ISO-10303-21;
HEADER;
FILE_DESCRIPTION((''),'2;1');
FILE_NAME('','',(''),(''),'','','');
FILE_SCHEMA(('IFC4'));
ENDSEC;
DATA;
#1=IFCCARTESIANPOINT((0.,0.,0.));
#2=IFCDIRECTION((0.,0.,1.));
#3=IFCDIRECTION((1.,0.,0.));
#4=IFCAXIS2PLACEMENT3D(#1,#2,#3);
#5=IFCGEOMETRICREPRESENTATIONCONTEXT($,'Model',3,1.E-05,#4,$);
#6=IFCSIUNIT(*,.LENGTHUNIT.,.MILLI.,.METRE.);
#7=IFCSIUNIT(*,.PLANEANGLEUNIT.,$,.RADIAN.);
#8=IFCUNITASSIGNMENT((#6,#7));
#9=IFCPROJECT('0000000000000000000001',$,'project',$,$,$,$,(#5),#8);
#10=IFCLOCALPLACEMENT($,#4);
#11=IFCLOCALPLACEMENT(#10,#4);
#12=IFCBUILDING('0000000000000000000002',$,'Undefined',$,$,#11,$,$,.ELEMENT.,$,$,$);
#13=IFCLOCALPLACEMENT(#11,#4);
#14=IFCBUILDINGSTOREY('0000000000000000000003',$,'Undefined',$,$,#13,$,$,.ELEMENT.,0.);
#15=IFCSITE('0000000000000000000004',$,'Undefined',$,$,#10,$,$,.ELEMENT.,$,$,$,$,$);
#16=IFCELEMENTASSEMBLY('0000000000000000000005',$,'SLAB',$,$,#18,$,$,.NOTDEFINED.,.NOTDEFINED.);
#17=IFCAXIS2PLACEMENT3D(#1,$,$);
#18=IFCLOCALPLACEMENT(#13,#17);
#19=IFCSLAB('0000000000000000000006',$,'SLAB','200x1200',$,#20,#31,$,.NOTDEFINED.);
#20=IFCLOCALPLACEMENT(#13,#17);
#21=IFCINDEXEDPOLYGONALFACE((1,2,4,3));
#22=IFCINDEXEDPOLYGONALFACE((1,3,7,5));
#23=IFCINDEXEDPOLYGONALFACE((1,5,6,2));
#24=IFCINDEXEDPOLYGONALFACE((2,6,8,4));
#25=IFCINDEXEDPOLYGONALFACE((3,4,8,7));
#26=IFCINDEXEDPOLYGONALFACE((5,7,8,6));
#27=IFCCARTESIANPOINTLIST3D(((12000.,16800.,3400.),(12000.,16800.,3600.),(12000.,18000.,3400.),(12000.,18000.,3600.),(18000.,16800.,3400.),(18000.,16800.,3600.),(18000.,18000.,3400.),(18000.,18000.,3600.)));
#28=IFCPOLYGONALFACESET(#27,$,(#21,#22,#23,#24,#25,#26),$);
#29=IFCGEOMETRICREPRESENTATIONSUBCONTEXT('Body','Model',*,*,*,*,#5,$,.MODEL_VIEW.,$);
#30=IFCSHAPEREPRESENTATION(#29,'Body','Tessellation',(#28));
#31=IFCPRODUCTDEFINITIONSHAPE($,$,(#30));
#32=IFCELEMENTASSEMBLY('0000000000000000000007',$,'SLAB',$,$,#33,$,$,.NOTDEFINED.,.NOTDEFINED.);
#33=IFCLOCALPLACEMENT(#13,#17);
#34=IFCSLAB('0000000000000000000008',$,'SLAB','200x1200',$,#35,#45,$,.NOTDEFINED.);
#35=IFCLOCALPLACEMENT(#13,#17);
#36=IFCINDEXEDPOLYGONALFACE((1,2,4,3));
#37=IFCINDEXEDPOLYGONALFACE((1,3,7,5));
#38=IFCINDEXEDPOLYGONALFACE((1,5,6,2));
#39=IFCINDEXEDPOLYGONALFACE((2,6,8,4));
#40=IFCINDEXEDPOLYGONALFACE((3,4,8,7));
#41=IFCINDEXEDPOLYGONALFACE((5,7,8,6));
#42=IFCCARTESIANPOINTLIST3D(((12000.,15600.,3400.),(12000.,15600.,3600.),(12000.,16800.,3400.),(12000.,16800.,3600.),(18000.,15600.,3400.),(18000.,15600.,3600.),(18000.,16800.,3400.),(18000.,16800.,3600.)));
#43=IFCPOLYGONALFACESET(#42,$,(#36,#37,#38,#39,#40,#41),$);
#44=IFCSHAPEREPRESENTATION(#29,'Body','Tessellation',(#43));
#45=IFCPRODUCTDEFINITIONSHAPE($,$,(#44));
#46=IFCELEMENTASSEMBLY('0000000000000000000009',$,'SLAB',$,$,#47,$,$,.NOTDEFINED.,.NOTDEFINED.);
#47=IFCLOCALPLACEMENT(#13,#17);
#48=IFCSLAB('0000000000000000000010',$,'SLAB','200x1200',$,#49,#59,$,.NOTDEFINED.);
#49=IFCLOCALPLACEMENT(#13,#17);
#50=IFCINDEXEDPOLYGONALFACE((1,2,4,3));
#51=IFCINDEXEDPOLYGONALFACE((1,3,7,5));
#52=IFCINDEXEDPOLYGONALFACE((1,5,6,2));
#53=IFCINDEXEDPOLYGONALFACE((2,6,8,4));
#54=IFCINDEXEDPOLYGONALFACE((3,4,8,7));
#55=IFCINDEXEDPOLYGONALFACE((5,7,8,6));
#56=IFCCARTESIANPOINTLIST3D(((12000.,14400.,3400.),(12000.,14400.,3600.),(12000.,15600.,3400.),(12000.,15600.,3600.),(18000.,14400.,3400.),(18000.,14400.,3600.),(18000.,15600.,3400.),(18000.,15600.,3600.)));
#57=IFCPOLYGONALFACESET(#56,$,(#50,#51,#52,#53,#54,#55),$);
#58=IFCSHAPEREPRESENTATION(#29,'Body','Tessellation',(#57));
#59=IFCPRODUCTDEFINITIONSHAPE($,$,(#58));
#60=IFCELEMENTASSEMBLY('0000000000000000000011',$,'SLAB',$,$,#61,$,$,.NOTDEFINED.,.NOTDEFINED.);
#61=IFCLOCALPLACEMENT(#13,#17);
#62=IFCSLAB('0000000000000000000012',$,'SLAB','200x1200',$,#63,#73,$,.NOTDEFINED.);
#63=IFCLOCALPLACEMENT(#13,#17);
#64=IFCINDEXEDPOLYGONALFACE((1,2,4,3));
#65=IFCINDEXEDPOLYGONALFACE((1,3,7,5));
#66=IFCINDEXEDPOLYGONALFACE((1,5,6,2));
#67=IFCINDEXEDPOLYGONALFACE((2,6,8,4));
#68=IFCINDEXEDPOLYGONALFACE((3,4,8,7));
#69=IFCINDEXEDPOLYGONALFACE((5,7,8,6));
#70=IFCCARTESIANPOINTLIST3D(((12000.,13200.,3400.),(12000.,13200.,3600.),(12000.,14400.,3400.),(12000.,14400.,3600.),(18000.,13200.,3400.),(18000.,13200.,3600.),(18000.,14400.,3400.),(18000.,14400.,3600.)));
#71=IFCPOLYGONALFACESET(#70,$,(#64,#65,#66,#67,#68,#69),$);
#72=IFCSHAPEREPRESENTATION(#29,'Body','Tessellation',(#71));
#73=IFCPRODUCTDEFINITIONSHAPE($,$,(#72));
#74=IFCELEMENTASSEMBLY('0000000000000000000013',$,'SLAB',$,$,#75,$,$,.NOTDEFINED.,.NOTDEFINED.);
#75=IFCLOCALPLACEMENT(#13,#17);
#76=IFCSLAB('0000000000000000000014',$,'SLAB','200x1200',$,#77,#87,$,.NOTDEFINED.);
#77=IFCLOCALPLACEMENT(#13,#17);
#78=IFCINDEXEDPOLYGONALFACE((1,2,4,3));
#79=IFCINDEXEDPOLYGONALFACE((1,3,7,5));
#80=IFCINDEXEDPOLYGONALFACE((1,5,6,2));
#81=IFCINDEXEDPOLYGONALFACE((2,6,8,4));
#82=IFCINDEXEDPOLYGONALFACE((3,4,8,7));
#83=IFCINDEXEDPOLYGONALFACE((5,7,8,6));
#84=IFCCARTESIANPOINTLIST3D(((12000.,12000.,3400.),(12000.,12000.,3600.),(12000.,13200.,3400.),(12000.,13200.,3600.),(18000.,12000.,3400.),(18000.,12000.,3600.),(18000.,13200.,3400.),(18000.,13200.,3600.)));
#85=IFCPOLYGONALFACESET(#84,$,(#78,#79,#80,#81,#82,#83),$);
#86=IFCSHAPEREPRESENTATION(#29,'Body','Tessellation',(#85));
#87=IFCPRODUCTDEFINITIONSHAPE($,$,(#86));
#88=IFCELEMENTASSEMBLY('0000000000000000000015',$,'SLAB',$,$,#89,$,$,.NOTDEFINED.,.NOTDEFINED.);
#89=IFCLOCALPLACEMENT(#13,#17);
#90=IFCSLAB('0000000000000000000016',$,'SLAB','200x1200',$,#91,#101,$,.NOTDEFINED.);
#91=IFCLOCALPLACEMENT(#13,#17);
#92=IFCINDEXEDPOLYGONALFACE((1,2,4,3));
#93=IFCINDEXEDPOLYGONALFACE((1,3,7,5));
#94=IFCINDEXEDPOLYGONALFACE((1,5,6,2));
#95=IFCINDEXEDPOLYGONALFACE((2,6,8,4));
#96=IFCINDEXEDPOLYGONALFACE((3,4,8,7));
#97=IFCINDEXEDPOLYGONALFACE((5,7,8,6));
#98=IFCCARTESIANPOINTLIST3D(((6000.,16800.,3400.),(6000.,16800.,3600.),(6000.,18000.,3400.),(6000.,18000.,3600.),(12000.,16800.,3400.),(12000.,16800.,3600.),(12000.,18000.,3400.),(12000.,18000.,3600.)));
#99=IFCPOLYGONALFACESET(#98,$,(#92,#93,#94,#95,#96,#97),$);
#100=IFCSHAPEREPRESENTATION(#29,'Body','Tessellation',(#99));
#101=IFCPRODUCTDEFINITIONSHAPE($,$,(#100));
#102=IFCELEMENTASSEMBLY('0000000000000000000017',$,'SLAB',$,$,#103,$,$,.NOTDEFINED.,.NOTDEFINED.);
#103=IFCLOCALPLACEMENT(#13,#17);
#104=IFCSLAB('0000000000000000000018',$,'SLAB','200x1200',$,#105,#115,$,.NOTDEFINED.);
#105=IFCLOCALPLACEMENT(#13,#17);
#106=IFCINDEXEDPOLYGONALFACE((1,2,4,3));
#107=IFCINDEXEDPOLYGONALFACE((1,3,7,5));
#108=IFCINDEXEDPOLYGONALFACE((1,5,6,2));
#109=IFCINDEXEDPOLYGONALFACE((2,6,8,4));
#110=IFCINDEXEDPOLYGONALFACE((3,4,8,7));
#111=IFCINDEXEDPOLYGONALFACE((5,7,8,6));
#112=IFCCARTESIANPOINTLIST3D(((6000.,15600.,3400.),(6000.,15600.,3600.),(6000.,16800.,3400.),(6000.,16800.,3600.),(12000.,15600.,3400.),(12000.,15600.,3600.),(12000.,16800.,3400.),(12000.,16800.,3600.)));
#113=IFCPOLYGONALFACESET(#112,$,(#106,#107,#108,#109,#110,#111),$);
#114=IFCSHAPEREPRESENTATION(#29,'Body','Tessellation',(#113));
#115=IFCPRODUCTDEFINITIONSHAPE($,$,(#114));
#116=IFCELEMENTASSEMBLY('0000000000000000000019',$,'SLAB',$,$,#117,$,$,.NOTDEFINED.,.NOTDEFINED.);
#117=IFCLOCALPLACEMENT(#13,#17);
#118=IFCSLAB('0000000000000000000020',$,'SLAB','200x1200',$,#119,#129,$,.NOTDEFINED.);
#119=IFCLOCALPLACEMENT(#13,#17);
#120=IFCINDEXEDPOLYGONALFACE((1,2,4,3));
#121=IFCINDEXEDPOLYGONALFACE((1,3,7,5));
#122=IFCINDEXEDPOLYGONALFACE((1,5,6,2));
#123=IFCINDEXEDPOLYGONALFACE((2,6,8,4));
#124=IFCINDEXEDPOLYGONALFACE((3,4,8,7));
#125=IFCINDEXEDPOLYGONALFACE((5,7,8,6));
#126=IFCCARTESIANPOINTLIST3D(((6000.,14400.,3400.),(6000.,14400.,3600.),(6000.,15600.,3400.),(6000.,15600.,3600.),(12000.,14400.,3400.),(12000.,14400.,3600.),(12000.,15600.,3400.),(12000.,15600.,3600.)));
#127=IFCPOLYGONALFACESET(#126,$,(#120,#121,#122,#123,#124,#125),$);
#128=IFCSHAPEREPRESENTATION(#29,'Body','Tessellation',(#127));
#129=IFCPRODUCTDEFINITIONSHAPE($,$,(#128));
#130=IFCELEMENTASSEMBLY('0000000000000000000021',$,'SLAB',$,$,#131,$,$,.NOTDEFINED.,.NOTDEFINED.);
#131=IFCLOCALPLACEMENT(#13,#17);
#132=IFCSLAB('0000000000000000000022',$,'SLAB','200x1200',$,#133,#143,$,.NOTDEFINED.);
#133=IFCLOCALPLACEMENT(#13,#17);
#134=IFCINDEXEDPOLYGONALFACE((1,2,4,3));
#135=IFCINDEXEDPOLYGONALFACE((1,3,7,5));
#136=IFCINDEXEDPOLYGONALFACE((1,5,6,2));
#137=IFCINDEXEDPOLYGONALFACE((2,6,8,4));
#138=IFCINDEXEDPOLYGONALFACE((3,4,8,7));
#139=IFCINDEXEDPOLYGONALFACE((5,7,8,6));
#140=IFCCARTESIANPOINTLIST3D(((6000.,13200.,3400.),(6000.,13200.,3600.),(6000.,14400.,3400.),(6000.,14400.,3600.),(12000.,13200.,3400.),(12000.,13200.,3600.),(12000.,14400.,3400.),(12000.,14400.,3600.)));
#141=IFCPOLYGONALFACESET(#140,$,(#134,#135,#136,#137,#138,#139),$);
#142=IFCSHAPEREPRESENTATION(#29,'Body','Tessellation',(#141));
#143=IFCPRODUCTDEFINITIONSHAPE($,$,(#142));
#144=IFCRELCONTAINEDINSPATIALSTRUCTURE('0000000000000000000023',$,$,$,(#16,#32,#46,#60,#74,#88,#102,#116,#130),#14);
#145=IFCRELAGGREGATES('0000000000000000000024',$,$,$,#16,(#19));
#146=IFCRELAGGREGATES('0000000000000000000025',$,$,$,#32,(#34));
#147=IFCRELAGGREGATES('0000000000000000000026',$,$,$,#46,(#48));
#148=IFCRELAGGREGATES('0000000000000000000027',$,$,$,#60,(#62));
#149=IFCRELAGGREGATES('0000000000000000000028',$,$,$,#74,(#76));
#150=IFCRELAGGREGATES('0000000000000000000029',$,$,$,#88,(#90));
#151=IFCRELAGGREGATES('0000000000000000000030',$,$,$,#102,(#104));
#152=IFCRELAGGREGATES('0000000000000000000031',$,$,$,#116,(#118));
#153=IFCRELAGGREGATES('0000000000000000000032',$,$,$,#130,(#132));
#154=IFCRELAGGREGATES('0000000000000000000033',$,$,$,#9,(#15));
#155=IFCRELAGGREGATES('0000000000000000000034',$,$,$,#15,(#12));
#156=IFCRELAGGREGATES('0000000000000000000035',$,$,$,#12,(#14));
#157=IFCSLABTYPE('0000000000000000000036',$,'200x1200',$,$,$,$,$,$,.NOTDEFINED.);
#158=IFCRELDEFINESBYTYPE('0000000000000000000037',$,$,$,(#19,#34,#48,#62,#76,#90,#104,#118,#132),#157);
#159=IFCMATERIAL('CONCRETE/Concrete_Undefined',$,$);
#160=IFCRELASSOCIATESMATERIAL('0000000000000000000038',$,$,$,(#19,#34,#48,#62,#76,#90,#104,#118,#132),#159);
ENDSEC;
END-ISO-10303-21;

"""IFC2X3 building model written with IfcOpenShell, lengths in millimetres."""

from ifc_helpers import new_model, si_unit, frame, origin_with_axes, place, context, subcontext, project, spatial, polyline, outline, extrude, material, type_object, element, aggregate, save


model = new_model("IFC2X3")

# Units and contexts
model_context = context("Model", 3, precision=1e-05, world=origin_with_axes())
body_context = subcontext(model_context, "Body", "Model", "MODEL_VIEW")
ifc_project = project(units=[si_unit("LENGTHUNIT", "METRE", prefix="MILLI"), si_unit("PLANEANGLEUNIT", "RADIAN")], contexts=[model_context])

# Site, building, storey
site_placement = place(None, origin_with_axes())
site = spatial("IfcSite", under=ifc_project, at=site_placement, Name="Undefined", CompositionType="ELEMENT")
building_placement = place(site_placement, origin_with_axes())
building = spatial("IfcBuilding", under=site, at=building_placement, Name="Undefined", CompositionType="ELEMENT")
storey_placement = place(building_placement, origin_with_axes())
storey = spatial("IfcBuildingStorey", under=building, at=storey_placement, Name="Undefined", CompositionType="ELEMENT", Elevation=0.0)

# Shared definitions
ifc_material_1 = material(Name="CONCRETE/Concrete_Undefined")

# Element assemblies, slabs
slab_type = type_object("IfcSlabType", Name="200x1200", PredefinedType="NOTDEFINED")
assembly_1_placement = place(storey_placement, origin_with_axes())
assembly_1 = element("IfcElementAssembly", 1, at=assembly_1_placement, inside=storey, Name="SLAB", AssemblyPlace="NOTDEFINED", PredefinedType="NOTDEFINED")
slab_1_placement = place(assembly_1_placement, frame((18000.0, 16800.0, 3500.0), z_axis=(0.0, 0.0, 1.0), x_axis=(0.0, 1.0, 0.0)))
slab_1 = element("IfcSlab", 2, at=slab_1_placement, type_object=slab_type, material=ifc_material_1, Name="SLAB", Description="200x1200", PredefinedType="NOTDEFINED", context=body_context, shape_type="SweptSolid", body=[
    extrude(outline(polyline([(0.0, 0.0), (1200.0, 0.0), (1200.0, 6000.0), (0.0, 6000.0), (0.0, 0.0)])), frame((0.0, 0.0, -100.0), z_axis=(0.0, 0.0, 1.0), x_axis=(1.0, 0.0, 0.0)), (0.0, 0.0, 1.0), 200.0),
])
aggregate(assembly_1, [slab_1])
assembly_2_placement = place(storey_placement, origin_with_axes())
assembly_2 = element("IfcElementAssembly", 3, at=assembly_2_placement, inside=storey, Name="SLAB", AssemblyPlace="NOTDEFINED", PredefinedType="NOTDEFINED")
slab_2_placement = place(assembly_2_placement, frame((18000.0, 15600.0, 3500.0), z_axis=(0.0, 0.0, 1.0), x_axis=(0.0, 1.0, 0.0)))
slab_2 = element("IfcSlab", 4, at=slab_2_placement, type_object=slab_type, material=ifc_material_1, Name="SLAB", Description="200x1200", PredefinedType="NOTDEFINED", context=body_context, shape_type="SweptSolid", body=[
    extrude(outline(polyline([(0.0, 0.0), (1200.0, 0.0), (1200.0, 6000.0), (0.0, 6000.0), (0.0, 0.0)])), frame((0.0, 0.0, -100.0), z_axis=(0.0, 0.0, 1.0), x_axis=(1.0, 0.0, 0.0)), (0.0, 0.0, 1.0), 200.0),
])
aggregate(assembly_2, [slab_2])
assembly_3_placement = place(storey_placement, origin_with_axes())
assembly_3 = element("IfcElementAssembly", 5, at=assembly_3_placement, inside=storey, Name="SLAB", AssemblyPlace="NOTDEFINED", PredefinedType="NOTDEFINED")
slab_3_placement = place(assembly_3_placement, frame((18000.0, 14400.0, 3500.0), z_axis=(0.0, 0.0, 1.0), x_axis=(0.0, 1.0, 0.0)))
slab_3 = element("IfcSlab", 6, at=slab_3_placement, type_object=slab_type, material=ifc_material_1, Name="SLAB", Description="200x1200", PredefinedType="NOTDEFINED", context=body_context, shape_type="SweptSolid", body=[
    extrude(outline(polyline([(0.0, 0.0), (1200.0, 0.0), (1200.0, 6000.0), (0.0, 6000.0), (0.0, 0.0)])), frame((0.0, 0.0, -100.0), z_axis=(0.0, 0.0, 1.0), x_axis=(1.0, 0.0, 0.0)), (0.0, 0.0, 1.0), 200.0),
])
aggregate(assembly_3, [slab_3])
assembly_4_placement = place(storey_placement, origin_with_axes())
assembly_4 = element("IfcElementAssembly", 7, at=assembly_4_placement, inside=storey, Name="SLAB", AssemblyPlace="NOTDEFINED", PredefinedType="NOTDEFINED")
slab_4_placement = place(assembly_4_placement, frame((18000.0, 13200.0, 3500.0), z_axis=(0.0, 0.0, 1.0), x_axis=(0.0, 1.0, 0.0)))
slab_4 = element("IfcSlab", 8, at=slab_4_placement, type_object=slab_type, material=ifc_material_1, Name="SLAB", Description="200x1200", PredefinedType="NOTDEFINED", context=body_context, shape_type="SweptSolid", body=[
    extrude(outline(polyline([(0.0, 0.0), (1200.0, 0.0), (1200.0, 6000.0), (0.0, 6000.0), (0.0, 0.0)])), frame((0.0, 0.0, -100.0), z_axis=(0.0, 0.0, 1.0), x_axis=(1.0, 0.0, 0.0)), (0.0, 0.0, 1.0), 200.0),
])
aggregate(assembly_4, [slab_4])
assembly_5_placement = place(storey_placement, origin_with_axes())
assembly_5 = element("IfcElementAssembly", 9, at=assembly_5_placement, inside=storey, Name="SLAB", AssemblyPlace="NOTDEFINED", PredefinedType="NOTDEFINED")
slab_5_placement = place(assembly_5_placement, frame((18000.0, 12000.0, 3500.0), z_axis=(0.0, 0.0, 1.0), x_axis=(0.0, 1.0, 0.0)))
slab_5 = element("IfcSlab", 10, at=slab_5_placement, type_object=slab_type, material=ifc_material_1, Name="SLAB", Description="200x1200", PredefinedType="NOTDEFINED", context=body_context, shape_type="SweptSolid", body=[
    extrude(outline(polyline([(0.0, 0.0), (1200.0, 0.0), (1200.0, 6000.0), (0.0, 6000.0), (0.0, 0.0)])), frame((0.0, 0.0, -100.0), z_axis=(0.0, 0.0, 1.0), x_axis=(1.0, 0.0, 0.0)), (0.0, 0.0, 1.0), 200.0),
])
aggregate(assembly_5, [slab_5])
assembly_6_placement = place(storey_placement, origin_with_axes())
assembly_6 = element("IfcElementAssembly", 11, at=assembly_6_placement, inside=storey, Name="SLAB", AssemblyPlace="NOTDEFINED", PredefinedType="NOTDEFINED")
slab_6_placement = place(assembly_6_placement, frame((12000.0, 16800.0, 3500.0), z_axis=(0.0, 0.0, 1.0), x_axis=(0.0, 1.0, 0.0)))
slab_6 = element("IfcSlab", 12, at=slab_6_placement, type_object=slab_type, material=ifc_material_1, Name="SLAB", Description="200x1200", PredefinedType="NOTDEFINED", context=body_context, shape_type="SweptSolid", body=[
    extrude(outline(polyline([(0.0, 0.0), (1200.0, 0.0), (1200.0, 6000.0), (0.0, 6000.0), (0.0, 0.0)])), frame((0.0, 0.0, -100.0), z_axis=(0.0, 0.0, 1.0), x_axis=(1.0, 0.0, 0.0)), (0.0, 0.0, 1.0), 200.0),
])
aggregate(assembly_6, [slab_6])
assembly_7_placement = place(storey_placement, origin_with_axes())
assembly_7 = element("IfcElementAssembly", 13, at=assembly_7_placement, inside=storey, Name="SLAB", AssemblyPlace="NOTDEFINED", PredefinedType="NOTDEFINED")
slab_7_placement = place(assembly_7_placement, frame((12000.0, 15600.0, 3500.0), z_axis=(0.0, 0.0, 1.0), x_axis=(0.0, 1.0, 0.0)))
slab_7 = element("IfcSlab", 14, at=slab_7_placement, type_object=slab_type, material=ifc_material_1, Name="SLAB", Description="200x1200", PredefinedType="NOTDEFINED", context=body_context, shape_type="SweptSolid", body=[
    extrude(outline(polyline([(0.0, 0.0), (1200.0, 0.0), (1200.0, 6000.0), (0.0, 6000.0), (0.0, 0.0)])), frame((0.0, 0.0, -100.0), z_axis=(0.0, 0.0, 1.0), x_axis=(1.0, 0.0, 0.0)), (0.0, 0.0, 1.0), 200.0),
])
aggregate(assembly_7, [slab_7])
assembly_8_placement = place(storey_placement, origin_with_axes())
assembly_8 = element("IfcElementAssembly", 15, at=assembly_8_placement, inside=storey, Name="SLAB", AssemblyPlace="NOTDEFINED", PredefinedType="NOTDEFINED")
slab_8_placement = place(assembly_8_placement, frame((12000.0, 14400.0, 3500.0), z_axis=(0.0, 0.0, 1.0), x_axis=(0.0, 1.0, 0.0)))
slab_8 = element("IfcSlab", 16, at=slab_8_placement, type_object=slab_type, material=ifc_material_1, Name="SLAB", Description="200x1200", PredefinedType="NOTDEFINED", context=body_context, shape_type="SweptSolid", body=[
    extrude(outline(polyline([(0.0, 0.0), (1200.0, 0.0), (1200.0, 6000.0), (0.0, 6000.0), (0.0, 0.0)])), frame((0.0, 0.0, -100.0), z_axis=(0.0, 0.0, 1.0), x_axis=(1.0, 0.0, 0.0)), (0.0, 0.0, 1.0), 200.0),
])
aggregate(assembly_8, [slab_8])
assembly_9_placement = place(storey_placement, origin_with_axes())
assembly_9 = element("IfcElementAssembly", 17, at=assembly_9_placement, inside=storey, Name="SLAB", AssemblyPlace="NOTDEFINED", PredefinedType="NOTDEFINED")
slab_9_placement = place(assembly_9_placement, frame((12000.0, 13200.0, 3500.0), z_axis=(0.0, 0.0, 1.0), x_axis=(0.0, 1.0, 0.0)))
slab_9 = element("IfcSlab", 18, at=slab_9_placement, type_object=slab_type, material=ifc_material_1, Name="SLAB", Description="200x1200", PredefinedType="NOTDEFINED", context=body_context, shape_type="SweptSolid", body=[
    extrude(outline(polyline([(0.0, 0.0), (1200.0, 0.0), (1200.0, 6000.0), (0.0, 6000.0), (0.0, 0.0)])), frame((0.0, 0.0, -100.0), z_axis=(0.0, 0.0, 1.0), x_axis=(1.0, 0.0, 0.0)), (0.0, 0.0, 1.0), 200.0),
])
aggregate(assembly_9, [slab_9])

save(model, "model.ifc")
